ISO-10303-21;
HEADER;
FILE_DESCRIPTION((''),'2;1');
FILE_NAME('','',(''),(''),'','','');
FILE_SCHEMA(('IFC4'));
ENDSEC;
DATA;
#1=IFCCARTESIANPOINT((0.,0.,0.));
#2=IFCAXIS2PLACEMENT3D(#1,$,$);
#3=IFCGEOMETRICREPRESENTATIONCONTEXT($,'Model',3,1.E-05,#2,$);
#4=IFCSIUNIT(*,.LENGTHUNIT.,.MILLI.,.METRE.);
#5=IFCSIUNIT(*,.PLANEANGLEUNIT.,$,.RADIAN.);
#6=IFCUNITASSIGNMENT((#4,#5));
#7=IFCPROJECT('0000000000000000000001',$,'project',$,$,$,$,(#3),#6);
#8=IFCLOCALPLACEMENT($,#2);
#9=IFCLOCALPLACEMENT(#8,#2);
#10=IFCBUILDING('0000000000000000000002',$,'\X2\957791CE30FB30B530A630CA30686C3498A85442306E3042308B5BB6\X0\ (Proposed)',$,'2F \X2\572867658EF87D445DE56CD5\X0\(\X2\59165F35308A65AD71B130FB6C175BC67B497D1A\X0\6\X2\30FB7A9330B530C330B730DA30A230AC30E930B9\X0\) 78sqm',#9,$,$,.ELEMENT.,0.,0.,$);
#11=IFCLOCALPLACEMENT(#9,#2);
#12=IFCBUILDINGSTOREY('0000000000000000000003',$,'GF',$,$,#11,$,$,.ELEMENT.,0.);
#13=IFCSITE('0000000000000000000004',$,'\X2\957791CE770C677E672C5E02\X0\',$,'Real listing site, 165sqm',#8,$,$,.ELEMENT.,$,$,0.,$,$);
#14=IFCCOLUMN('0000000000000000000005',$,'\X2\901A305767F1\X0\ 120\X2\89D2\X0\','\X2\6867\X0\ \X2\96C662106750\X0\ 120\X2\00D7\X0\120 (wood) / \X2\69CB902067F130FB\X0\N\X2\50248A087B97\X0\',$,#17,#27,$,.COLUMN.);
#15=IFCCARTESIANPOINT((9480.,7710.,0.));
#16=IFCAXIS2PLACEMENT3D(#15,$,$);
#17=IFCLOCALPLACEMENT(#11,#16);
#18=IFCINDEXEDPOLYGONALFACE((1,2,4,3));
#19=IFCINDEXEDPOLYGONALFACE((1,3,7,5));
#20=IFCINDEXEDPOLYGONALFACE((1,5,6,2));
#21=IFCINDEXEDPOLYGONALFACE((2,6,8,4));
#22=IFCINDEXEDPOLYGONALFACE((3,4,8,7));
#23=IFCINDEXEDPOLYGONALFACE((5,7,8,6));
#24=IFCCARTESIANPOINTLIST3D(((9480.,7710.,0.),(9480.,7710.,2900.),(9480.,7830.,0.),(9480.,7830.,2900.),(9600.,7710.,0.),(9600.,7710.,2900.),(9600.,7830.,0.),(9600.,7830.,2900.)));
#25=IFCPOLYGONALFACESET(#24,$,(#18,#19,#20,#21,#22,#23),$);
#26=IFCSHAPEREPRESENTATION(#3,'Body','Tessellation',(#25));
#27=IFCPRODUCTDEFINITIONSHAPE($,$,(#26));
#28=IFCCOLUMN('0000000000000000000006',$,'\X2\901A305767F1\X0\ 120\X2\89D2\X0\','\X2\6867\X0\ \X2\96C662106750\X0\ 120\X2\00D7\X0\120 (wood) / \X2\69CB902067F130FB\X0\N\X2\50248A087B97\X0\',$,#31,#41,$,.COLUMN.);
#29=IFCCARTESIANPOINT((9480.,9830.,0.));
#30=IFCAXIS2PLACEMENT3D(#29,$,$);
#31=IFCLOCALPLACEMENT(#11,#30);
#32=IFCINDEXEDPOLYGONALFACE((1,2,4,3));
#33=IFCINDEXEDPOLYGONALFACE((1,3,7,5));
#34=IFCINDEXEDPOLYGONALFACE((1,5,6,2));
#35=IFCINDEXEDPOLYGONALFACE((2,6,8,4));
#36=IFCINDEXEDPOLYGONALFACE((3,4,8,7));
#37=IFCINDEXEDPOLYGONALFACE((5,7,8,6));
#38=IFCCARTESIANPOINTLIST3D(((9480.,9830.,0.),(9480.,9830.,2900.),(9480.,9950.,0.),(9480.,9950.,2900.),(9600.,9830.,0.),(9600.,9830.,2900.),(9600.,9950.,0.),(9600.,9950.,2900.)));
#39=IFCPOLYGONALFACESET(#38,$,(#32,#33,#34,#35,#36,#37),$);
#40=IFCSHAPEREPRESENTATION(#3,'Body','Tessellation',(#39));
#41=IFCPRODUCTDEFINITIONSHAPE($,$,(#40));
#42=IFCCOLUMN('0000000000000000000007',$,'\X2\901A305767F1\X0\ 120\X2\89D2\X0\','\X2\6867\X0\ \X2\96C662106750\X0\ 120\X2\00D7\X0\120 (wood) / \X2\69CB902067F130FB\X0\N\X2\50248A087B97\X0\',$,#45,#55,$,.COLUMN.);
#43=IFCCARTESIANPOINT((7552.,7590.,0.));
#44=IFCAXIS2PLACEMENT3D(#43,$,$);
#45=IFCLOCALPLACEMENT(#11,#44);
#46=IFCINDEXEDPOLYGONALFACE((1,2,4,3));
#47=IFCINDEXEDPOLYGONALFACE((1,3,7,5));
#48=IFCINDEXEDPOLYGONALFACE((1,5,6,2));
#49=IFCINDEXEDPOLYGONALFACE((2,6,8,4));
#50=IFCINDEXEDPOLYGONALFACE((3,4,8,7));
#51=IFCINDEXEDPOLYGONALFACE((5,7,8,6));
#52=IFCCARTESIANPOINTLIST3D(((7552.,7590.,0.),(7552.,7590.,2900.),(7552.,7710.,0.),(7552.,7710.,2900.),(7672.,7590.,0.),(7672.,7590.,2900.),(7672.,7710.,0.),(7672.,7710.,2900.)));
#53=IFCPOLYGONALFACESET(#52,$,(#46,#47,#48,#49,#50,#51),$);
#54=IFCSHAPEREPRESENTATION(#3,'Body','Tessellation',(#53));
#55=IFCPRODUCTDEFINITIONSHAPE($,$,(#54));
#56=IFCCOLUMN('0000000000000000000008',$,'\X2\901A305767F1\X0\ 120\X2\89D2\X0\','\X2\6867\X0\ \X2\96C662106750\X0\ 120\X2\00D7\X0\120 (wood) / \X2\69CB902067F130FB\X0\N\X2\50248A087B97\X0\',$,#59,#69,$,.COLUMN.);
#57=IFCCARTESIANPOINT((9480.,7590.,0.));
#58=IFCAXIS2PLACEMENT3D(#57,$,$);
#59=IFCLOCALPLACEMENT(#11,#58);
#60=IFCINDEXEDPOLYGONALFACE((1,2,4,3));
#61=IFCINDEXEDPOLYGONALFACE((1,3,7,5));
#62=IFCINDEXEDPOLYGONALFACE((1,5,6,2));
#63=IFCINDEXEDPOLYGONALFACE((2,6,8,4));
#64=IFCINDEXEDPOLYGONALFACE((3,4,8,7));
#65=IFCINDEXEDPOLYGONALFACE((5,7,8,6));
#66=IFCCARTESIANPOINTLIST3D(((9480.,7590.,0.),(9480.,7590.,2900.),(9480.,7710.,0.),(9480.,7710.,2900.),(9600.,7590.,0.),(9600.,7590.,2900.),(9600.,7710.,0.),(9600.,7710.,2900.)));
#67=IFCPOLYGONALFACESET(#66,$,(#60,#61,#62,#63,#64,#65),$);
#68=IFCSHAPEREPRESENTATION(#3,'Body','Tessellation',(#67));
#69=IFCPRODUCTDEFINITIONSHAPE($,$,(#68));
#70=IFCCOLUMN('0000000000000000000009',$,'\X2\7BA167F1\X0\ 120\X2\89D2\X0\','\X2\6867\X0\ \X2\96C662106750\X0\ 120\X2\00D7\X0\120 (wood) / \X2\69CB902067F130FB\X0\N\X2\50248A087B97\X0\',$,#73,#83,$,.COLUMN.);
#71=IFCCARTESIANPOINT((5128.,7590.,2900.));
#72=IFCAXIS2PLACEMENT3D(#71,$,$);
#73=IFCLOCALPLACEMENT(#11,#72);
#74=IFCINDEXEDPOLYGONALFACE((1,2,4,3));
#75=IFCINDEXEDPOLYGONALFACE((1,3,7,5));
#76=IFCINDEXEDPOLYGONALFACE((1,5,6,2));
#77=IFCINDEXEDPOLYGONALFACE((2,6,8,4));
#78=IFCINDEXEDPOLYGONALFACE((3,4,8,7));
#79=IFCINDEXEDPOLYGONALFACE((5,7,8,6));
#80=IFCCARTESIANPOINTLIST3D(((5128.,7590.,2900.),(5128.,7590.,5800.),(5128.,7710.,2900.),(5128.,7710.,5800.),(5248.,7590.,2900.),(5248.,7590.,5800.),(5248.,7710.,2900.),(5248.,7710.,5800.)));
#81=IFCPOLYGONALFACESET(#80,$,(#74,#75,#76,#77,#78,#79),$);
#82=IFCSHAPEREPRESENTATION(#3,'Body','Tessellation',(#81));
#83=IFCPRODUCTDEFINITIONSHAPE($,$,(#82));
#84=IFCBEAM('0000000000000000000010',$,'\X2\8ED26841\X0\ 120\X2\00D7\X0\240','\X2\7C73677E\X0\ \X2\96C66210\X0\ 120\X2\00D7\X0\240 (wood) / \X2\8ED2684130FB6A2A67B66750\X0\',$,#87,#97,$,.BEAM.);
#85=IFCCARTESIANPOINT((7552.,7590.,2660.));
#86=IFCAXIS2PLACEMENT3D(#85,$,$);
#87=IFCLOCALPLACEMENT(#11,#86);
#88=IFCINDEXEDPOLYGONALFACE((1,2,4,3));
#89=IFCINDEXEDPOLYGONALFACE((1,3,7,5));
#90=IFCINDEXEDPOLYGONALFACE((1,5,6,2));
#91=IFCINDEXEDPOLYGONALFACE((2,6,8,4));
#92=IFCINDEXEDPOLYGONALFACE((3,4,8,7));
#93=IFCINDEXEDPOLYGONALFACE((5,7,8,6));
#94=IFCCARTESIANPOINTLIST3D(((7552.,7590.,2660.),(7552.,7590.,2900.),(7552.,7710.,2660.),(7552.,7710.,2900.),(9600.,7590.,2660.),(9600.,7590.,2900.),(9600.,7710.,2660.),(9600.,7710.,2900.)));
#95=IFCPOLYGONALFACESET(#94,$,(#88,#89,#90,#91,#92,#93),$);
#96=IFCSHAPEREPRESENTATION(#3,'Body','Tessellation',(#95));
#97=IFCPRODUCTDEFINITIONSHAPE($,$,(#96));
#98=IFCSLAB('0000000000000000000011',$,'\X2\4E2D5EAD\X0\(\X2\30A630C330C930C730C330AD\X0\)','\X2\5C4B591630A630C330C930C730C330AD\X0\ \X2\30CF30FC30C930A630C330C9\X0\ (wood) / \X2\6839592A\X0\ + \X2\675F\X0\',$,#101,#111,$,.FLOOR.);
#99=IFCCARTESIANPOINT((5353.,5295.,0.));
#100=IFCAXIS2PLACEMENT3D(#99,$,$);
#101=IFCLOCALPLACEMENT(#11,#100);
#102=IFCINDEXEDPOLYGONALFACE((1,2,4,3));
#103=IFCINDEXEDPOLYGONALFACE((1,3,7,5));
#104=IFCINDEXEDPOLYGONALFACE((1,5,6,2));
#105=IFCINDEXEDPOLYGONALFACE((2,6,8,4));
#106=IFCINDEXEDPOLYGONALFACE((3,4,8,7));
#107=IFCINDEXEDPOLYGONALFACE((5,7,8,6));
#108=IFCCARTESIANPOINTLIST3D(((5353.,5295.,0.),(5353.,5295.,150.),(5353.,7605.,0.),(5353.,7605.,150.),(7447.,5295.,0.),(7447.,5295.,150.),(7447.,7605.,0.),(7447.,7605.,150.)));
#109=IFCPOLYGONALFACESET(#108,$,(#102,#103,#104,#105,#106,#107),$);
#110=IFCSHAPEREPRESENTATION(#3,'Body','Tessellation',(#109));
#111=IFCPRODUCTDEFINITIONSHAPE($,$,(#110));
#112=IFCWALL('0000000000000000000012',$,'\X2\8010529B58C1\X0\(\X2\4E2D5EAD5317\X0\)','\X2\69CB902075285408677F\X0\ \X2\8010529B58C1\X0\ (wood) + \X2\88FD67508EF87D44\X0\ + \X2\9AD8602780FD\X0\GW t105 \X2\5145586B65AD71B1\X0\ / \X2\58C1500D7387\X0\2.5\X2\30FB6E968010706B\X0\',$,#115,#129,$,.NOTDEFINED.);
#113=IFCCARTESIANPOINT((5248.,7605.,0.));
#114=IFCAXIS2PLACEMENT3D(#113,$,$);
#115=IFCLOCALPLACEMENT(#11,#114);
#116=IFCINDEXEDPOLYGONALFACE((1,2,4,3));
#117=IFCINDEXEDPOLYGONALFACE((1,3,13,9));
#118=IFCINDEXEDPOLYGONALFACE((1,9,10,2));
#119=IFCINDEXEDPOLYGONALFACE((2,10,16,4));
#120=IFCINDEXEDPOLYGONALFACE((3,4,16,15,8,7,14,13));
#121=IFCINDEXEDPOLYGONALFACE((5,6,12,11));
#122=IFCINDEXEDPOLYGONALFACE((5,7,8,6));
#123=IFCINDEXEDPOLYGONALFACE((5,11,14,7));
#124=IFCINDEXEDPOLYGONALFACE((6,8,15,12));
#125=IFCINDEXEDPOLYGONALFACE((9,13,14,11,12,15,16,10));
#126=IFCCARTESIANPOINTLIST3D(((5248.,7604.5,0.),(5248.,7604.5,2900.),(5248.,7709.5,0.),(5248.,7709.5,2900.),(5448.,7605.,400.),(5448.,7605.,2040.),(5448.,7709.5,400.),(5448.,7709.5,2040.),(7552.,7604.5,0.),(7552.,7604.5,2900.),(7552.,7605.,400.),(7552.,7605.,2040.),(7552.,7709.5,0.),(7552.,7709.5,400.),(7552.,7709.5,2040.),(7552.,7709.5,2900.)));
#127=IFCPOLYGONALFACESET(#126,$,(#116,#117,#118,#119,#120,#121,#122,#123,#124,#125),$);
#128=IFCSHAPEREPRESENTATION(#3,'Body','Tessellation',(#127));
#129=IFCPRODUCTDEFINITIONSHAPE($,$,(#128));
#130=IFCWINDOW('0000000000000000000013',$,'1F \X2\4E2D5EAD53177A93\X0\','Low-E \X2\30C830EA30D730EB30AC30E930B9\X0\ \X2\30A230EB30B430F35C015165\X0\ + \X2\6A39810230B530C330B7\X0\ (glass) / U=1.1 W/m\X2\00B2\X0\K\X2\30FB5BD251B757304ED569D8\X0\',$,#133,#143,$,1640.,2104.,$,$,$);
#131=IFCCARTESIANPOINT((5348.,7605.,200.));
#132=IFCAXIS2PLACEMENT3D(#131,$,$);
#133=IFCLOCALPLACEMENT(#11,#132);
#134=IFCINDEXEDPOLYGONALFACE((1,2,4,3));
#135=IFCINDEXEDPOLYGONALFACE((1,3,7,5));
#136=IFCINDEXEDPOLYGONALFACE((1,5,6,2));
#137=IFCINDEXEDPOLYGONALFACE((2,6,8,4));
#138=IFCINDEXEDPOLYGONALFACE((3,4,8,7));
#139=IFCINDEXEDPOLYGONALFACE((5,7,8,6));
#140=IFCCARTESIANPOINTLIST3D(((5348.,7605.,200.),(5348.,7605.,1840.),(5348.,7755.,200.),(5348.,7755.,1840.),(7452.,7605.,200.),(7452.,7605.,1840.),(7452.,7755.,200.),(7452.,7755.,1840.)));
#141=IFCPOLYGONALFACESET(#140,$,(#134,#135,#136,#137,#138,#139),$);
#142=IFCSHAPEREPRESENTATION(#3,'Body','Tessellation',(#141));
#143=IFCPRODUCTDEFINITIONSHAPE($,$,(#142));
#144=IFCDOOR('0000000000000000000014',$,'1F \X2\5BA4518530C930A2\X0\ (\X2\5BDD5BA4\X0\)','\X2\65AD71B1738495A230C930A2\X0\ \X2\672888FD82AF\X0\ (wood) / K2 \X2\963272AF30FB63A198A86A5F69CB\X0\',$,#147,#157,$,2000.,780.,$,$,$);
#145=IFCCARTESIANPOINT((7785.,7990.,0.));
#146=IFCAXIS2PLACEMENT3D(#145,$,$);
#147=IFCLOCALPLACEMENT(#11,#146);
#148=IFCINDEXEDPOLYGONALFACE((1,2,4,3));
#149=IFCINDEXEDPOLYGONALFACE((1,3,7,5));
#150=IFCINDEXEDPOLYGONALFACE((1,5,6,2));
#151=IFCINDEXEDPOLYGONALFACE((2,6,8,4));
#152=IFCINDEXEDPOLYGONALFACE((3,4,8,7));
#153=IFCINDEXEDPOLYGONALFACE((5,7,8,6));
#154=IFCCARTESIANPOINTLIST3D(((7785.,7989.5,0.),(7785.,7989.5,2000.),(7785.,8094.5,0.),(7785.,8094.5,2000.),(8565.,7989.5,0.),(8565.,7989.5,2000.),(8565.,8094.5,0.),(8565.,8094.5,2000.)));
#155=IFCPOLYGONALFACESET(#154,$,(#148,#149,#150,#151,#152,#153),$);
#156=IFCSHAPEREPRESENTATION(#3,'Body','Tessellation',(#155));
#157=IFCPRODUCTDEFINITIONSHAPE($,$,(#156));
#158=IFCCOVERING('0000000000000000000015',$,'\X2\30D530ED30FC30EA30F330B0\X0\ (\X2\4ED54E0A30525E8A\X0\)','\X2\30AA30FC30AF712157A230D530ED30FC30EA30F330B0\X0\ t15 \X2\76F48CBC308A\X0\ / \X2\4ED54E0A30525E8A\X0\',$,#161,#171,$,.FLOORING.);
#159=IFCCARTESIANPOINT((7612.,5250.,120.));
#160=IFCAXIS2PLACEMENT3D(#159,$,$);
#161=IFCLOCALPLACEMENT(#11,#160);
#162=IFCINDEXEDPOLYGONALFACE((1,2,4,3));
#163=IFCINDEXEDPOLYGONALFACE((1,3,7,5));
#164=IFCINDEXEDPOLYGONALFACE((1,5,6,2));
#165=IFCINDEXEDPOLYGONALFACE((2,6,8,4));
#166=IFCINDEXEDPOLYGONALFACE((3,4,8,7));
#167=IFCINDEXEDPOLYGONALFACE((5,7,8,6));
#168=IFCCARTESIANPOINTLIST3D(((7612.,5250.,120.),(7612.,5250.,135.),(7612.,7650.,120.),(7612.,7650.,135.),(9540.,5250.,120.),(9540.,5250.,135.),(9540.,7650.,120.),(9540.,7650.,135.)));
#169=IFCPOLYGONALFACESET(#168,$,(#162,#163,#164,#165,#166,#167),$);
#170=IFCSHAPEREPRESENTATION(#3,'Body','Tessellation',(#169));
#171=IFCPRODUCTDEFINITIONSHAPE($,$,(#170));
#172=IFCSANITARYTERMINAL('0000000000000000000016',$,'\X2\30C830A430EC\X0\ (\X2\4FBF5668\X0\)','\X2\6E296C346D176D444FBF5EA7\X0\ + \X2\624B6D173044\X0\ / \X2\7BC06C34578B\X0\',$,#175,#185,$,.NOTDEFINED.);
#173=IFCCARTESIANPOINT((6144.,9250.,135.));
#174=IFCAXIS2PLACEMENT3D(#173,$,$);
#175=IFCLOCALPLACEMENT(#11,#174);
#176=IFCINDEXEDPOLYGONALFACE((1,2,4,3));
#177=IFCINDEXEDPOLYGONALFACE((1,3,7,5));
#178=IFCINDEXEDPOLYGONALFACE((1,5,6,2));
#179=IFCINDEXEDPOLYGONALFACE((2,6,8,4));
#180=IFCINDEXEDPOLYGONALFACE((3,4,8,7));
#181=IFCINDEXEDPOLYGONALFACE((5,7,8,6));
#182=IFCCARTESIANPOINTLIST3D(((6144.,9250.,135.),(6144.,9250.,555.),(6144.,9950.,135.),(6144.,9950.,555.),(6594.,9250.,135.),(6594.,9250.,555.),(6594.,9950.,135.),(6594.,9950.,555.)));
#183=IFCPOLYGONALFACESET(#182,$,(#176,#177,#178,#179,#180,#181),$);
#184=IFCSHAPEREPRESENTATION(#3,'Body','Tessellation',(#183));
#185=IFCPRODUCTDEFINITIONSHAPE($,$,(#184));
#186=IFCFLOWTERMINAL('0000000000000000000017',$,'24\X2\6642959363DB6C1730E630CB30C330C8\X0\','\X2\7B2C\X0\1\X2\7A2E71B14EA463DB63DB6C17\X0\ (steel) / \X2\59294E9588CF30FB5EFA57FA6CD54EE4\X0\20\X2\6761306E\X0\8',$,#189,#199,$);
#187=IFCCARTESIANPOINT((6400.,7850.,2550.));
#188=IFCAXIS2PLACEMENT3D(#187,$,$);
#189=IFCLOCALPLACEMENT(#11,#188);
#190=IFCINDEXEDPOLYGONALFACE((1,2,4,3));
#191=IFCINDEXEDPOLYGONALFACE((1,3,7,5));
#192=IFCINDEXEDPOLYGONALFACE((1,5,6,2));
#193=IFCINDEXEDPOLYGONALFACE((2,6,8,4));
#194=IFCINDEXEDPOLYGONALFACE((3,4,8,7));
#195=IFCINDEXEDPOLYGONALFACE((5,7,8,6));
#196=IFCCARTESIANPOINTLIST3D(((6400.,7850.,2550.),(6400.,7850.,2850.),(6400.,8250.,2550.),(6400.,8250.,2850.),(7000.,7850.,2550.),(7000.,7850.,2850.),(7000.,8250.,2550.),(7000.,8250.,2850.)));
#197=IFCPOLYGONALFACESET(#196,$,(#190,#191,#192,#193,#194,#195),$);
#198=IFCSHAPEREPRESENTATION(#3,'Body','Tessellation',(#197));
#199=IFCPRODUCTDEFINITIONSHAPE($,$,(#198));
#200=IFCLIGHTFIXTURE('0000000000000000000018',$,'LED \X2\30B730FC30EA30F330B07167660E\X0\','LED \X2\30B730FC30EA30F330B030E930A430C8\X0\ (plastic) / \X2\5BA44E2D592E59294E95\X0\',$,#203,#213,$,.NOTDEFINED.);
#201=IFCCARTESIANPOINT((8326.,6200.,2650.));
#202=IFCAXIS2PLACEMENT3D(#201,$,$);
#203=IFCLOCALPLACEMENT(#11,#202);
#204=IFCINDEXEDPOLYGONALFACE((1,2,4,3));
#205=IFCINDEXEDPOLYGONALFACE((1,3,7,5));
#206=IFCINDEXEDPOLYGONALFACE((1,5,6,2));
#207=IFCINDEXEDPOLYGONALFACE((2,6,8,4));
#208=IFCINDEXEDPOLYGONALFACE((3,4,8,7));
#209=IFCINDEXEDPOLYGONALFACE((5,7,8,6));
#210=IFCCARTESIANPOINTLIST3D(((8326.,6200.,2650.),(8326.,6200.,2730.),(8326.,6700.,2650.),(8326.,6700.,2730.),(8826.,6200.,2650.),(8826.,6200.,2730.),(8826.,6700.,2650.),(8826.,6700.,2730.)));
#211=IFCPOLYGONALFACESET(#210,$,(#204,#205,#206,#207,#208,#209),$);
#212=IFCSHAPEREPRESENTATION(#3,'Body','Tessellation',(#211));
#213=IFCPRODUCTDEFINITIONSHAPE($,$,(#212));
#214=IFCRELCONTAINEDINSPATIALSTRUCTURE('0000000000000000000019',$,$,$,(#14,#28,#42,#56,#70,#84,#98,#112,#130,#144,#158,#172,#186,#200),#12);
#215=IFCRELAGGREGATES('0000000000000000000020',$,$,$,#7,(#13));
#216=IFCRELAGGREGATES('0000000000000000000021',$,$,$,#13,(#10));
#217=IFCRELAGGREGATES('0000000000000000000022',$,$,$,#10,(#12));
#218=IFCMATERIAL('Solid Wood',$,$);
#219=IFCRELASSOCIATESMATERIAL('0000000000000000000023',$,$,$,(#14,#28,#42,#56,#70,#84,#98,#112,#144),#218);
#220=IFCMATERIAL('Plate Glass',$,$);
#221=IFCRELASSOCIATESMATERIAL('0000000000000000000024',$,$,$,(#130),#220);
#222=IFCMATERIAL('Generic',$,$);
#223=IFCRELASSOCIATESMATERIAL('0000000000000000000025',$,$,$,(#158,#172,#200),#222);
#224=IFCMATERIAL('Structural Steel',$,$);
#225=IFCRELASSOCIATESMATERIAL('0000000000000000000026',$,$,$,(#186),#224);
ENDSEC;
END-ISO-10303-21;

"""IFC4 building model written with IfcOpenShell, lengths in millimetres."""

from ifc_helpers import new_model, si_unit, frame, frame_2d, origin, place, context, project, spatial, rectangle, extrude, material, element, fill, save


model = new_model("IFC4")

# Units and contexts
model_context = context("Model", 3, precision=1e-05, world=origin())
ifc_project = project(units=[si_unit("LENGTHUNIT", "METRE", prefix="MILLI"), si_unit("PLANEANGLEUNIT", "RADIAN")], contexts=[model_context])

# Site, building, storey
site_placement = place(None, origin())
site = spatial("IfcSite", under=ifc_project, at=site_placement, Name="長野県松本市", ObjectType="Real listing site, 165sqm", CompositionType="ELEMENT", RefElevation=0.0)
building_placement = place(site_placement, origin())
building = spatial("IfcBuilding", under=site, at=building_placement, Name="長野・サウナと水風呂のある家 (Proposed)", ObjectType="2F 在来軸組工法(外張り断熱・気密等級6・窓サッシペアガラス) 78sqm", CompositionType="ELEMENT", ElevationOfRefHeight=0.0, ElevationOfTerrain=0.0)
storey_placement = place(building_placement, origin())
storey = spatial("IfcBuildingStorey", under=building, at=storey_placement, Name="GF", CompositionType="ELEMENT", Elevation=0.0)

# Columns
ifc_material_1 = material(Name="Solid Wood")
column_1_placement = place(storey_placement, frame((9480.0, 7710.0, 0.0)))
element("IfcColumn", 1, at=column_1_placement, inside=storey, material=ifc_material_1, Name="通し柱 120角", Description="桧 集成材 120×120 (wood) / 構造柱・N値計算", PredefinedType="COLUMN", context=model_context, shape_type="SweptSolid", body=[
    extrude(rectangle(XDim=120.0, YDim=120.0, at=frame_2d((60.0, 60.0))), frame((9480.0, 7710.0, 0.0)), (0.0, 0.0, 1.0), 2900.0),
])
column_2_placement = place(storey_placement, frame((9480.0, 9830.0, 0.0)))
element("IfcColumn", 2, at=column_2_placement, inside=storey, material=ifc_material_1, Name="通し柱 120角", Description="桧 集成材 120×120 (wood) / 構造柱・N値計算", PredefinedType="COLUMN", context=model_context, shape_type="SweptSolid", body=[
    extrude(rectangle(XDim=120.0, YDim=120.0, at=frame_2d((60.0, 60.0))), frame((9480.0, 9830.0, 0.0)), (0.0, 0.0, 1.0), 2900.0),
])
column_3_placement = place(storey_placement, frame((7552.0, 7590.0, 0.0)))
element("IfcColumn", 3, at=column_3_placement, inside=storey, material=ifc_material_1, Name="通し柱 120角", Description="桧 集成材 120×120 (wood) / 構造柱・N値計算", PredefinedType="COLUMN", context=model_context, shape_type="SweptSolid", body=[
    extrude(rectangle(XDim=120.0, YDim=120.0, at=frame_2d((60.0, 60.0))), frame((7552.0, 7590.0, 0.0)), (0.0, 0.0, 1.0), 2900.0),
])
column_4_placement = place(storey_placement, frame((9480.0, 7590.0, 0.0)))
element("IfcColumn", 4, at=column_4_placement, inside=storey, material=ifc_material_1, Name="通し柱 120角", Description="桧 集成材 120×120 (wood) / 構造柱・N値計算", PredefinedType="COLUMN", context=model_context, shape_type="SweptSolid", body=[
    extrude(rectangle(XDim=120.0, YDim=120.0, at=frame_2d((60.0, 60.0))), frame((9480.0, 7590.0, 0.0)), (0.0, 0.0, 1.0), 2900.0),
])
column_5_placement = place(storey_placement, frame((5128.0, 7590.0, 2900.0)))
element("IfcColumn", 5, at=column_5_placement, inside=storey, material=ifc_material_1, Name="管柱 120角", Description="桧 集成材 120×120 (wood) / 構造柱・N値計算", PredefinedType="COLUMN", context=model_context, shape_type="SweptSolid", body=[
    extrude(rectangle(XDim=120.0, YDim=120.0, at=frame_2d((60.0, 60.0))), frame((5128.0, 7590.0, 2900.0)), (0.0, 0.0, 1.0), 2900.0),
])

# Beam
beam_1_placement = place(storey_placement, frame((7552.0, 7590.0, 2660.0)))
element("IfcBeam", 6, at=beam_1_placement, inside=storey, material=ifc_material_1, Name="軒桁 120×240", Description="米松 集成 120×240 (wood) / 軒桁・横架材", PredefinedType="BEAM", context=model_context, shape_type="SweptSolid", body=[
    extrude(rectangle(XDim=2048.0, YDim=120.0, at=frame_2d((1024.0, 60.0))), frame((7552.0, 7590.0, 2660.0)), (0.0, 0.0, 1.0), 240.0),
])

# Slab
slab_placement = place(storey_placement, frame((5353.0, 5295.0, 0.0)))
element("IfcSlab", 7, at=slab_placement, inside=storey, material=ifc_material_1, Name="中庭(ウッドデッキ)", Description="屋外ウッドデッキ ハードウッド (wood) / 根太 + 束", PredefinedType="FLOOR", context=model_context, shape_type="SweptSolid", body=[
    extrude(rectangle(XDim=2094.0, YDim=2310.0, at=frame_2d((1047.0, 1155.0))), frame((5353.0, 5295.0, 0.0)), (0.0, 0.0, 1.0), 150.0),
])

# Wall, opening, window
wall_1_placement = place(storey_placement, frame((5248.0, 7605.0, 0.0)))
wall_1 = element("IfcWall", 8, at=wall_1_placement, inside=storey, material=ifc_material_1, Name="耐力壁(中庭北)", Description="構造用合板 耐力壁 (wood) + 製材軸組 + 高性能GW t105 充填断熱 / 壁倍率2.5・準耐火", PredefinedType="NOTDEFINED", context=model_context, shape_type="SweptSolid", body=[
    extrude(rectangle(XDim=2304.0, YDim=105.0, at=frame_2d((1152.0, 52.0))), frame((5248.0, 7605.0, 0.0)), (0.0, 0.0, 1.0), 2900.0),
])
opening_placement = place(storey_placement, frame((5348.0, 7605.0, 200.0)))
opening = element("IfcOpeningElement", 9, at=opening_placement, cuts=wall_1, PredefinedType="NOTDEFINED", context=model_context, shape_type="SweptSolid", body=[
    extrude(rectangle(XDim=2104.0, YDim=150.0, at=frame_2d((1052.0, 75.0))), frame((5348.0, 7605.0, 200.0)), (0.0, 0.0, 1.0), 1640.0),
])
ifc_material_2 = material(Name="Plate Glass")
window_placement = place(storey_placement, frame((5348.0, 7605.0, 200.0)))
window = element("IfcWindow", 10, at=window_placement, inside=storey, material=ifc_material_2, Name="1F 中庭北窓", Description="Low-E トリプルガラス アルゴン封入 + 樹脂サッシ (glass) / U=1.1 W/m²K・寒冷地仕様", OverallHeight=1640.0, OverallWidth=2104.0, context=model_context, shape_type="SweptSolid", body=[
    extrude(rectangle(XDim=2104.0, YDim=150.0, at=frame_2d((1052.0, 75.0))), frame((5348.0, 7605.0, 200.0)), (0.0, 0.0, 1.0), 1640.0),
])
fill(opening, window)

# Door
door_placement = place(storey_placement, frame((7785.0, 7990.0, 0.0)))
element("IfcDoor", 11, at=door_placement, inside=storey, material=ifc_material_1, Name="1F 室内ドア (寝室)", Description="断熱玄関ドア 木製芯 (wood) / K2 防犯・採風機構", OverallHeight=2000.0, OverallWidth=780.0, context=model_context, shape_type="SweptSolid", body=[
    extrude(rectangle(XDim=780.0, YDim=105.0, at=frame_2d((390.0, 52.0))), frame((7785.0, 7990.0, 0.0)), (0.0, 0.0, 1.0), 2000.0),
])

# Covering
ifc_material_3 = material(Name="Generic")
covering_placement = place(storey_placement, frame((7612.0, 5250.0, 120.0)))
element("IfcCovering", 12, at=covering_placement, inside=storey, material=ifc_material_3, Name="フローリング (仕上げ床)", Description="オーク無垢フローリング t15 直貼り / 仕上げ床", PredefinedType="FLOORING", context=model_context, shape_type="SweptSolid", body=[
    extrude(rectangle(XDim=1928.0, YDim=2400.0, at=frame_2d((964.0, 1200.0))), frame((7612.0, 5250.0, 120.0)), (0.0, 0.0, 1.0), 15.0),
])

# Sanitary terminal
sanitary_terminal_placement = place(storey_placement, frame((6144.0, 9250.0, 135.0)))
element("IfcSanitaryTerminal", 13, at=sanitary_terminal_placement, inside=storey, material=ifc_material_3, Name="トイレ (便器)", Description="温水洗浄便座 + 手洗い / 節水型", PredefinedType="NOTDEFINED", context=model_context, shape_type="SweptSolid", body=[
    extrude(rectangle(XDim=450.0, YDim=700.0, at=frame_2d((225.0, 350.0))), frame((6144.0, 9250.0, 135.0)), (0.0, 0.0, 1.0), 420.0),
])

# Flow terminal
ifc_material_4 = material(Name="Structural Steel")
flow_terminal_placement = place(storey_placement, frame((6400.0, 7850.0, 2550.0)))
element("IfcFlowTerminal", 14, at=flow_terminal_placement, inside=storey, material=ifc_material_4, Name="24時間換気ユニット", Description="第1種熱交換換気 (steel) / 天井裏・建基法令20条の8", context=model_context, shape_type="SweptSolid", body=[
    extrude(rectangle(XDim=600.0, YDim=400.0, at=frame_2d((300.0, 200.0))), frame((6400.0, 7850.0, 2550.0)), (0.0, 0.0, 1.0), 300.0),
])

# Light fixture
light_fixture_placement = place(storey_placement, frame((8326.0, 6200.0, 2650.0)))
element("IfcLightFixture", 15, at=light_fixture_placement, inside=storey, material=ifc_material_3, Name="LED シーリング照明", Description="LED シーリングライト (plastic) / 室中央天井", PredefinedType="NOTDEFINED", context=model_context, shape_type="SweptSolid", body=[
    extrude(rectangle(XDim=500.0, YDim=500.0, at=frame_2d((250.0, 250.0))), frame((8326.0, 6200.0, 2650.0)), (0.0, 0.0, 1.0), 80.0),
])

save(model, "model.ifc")
